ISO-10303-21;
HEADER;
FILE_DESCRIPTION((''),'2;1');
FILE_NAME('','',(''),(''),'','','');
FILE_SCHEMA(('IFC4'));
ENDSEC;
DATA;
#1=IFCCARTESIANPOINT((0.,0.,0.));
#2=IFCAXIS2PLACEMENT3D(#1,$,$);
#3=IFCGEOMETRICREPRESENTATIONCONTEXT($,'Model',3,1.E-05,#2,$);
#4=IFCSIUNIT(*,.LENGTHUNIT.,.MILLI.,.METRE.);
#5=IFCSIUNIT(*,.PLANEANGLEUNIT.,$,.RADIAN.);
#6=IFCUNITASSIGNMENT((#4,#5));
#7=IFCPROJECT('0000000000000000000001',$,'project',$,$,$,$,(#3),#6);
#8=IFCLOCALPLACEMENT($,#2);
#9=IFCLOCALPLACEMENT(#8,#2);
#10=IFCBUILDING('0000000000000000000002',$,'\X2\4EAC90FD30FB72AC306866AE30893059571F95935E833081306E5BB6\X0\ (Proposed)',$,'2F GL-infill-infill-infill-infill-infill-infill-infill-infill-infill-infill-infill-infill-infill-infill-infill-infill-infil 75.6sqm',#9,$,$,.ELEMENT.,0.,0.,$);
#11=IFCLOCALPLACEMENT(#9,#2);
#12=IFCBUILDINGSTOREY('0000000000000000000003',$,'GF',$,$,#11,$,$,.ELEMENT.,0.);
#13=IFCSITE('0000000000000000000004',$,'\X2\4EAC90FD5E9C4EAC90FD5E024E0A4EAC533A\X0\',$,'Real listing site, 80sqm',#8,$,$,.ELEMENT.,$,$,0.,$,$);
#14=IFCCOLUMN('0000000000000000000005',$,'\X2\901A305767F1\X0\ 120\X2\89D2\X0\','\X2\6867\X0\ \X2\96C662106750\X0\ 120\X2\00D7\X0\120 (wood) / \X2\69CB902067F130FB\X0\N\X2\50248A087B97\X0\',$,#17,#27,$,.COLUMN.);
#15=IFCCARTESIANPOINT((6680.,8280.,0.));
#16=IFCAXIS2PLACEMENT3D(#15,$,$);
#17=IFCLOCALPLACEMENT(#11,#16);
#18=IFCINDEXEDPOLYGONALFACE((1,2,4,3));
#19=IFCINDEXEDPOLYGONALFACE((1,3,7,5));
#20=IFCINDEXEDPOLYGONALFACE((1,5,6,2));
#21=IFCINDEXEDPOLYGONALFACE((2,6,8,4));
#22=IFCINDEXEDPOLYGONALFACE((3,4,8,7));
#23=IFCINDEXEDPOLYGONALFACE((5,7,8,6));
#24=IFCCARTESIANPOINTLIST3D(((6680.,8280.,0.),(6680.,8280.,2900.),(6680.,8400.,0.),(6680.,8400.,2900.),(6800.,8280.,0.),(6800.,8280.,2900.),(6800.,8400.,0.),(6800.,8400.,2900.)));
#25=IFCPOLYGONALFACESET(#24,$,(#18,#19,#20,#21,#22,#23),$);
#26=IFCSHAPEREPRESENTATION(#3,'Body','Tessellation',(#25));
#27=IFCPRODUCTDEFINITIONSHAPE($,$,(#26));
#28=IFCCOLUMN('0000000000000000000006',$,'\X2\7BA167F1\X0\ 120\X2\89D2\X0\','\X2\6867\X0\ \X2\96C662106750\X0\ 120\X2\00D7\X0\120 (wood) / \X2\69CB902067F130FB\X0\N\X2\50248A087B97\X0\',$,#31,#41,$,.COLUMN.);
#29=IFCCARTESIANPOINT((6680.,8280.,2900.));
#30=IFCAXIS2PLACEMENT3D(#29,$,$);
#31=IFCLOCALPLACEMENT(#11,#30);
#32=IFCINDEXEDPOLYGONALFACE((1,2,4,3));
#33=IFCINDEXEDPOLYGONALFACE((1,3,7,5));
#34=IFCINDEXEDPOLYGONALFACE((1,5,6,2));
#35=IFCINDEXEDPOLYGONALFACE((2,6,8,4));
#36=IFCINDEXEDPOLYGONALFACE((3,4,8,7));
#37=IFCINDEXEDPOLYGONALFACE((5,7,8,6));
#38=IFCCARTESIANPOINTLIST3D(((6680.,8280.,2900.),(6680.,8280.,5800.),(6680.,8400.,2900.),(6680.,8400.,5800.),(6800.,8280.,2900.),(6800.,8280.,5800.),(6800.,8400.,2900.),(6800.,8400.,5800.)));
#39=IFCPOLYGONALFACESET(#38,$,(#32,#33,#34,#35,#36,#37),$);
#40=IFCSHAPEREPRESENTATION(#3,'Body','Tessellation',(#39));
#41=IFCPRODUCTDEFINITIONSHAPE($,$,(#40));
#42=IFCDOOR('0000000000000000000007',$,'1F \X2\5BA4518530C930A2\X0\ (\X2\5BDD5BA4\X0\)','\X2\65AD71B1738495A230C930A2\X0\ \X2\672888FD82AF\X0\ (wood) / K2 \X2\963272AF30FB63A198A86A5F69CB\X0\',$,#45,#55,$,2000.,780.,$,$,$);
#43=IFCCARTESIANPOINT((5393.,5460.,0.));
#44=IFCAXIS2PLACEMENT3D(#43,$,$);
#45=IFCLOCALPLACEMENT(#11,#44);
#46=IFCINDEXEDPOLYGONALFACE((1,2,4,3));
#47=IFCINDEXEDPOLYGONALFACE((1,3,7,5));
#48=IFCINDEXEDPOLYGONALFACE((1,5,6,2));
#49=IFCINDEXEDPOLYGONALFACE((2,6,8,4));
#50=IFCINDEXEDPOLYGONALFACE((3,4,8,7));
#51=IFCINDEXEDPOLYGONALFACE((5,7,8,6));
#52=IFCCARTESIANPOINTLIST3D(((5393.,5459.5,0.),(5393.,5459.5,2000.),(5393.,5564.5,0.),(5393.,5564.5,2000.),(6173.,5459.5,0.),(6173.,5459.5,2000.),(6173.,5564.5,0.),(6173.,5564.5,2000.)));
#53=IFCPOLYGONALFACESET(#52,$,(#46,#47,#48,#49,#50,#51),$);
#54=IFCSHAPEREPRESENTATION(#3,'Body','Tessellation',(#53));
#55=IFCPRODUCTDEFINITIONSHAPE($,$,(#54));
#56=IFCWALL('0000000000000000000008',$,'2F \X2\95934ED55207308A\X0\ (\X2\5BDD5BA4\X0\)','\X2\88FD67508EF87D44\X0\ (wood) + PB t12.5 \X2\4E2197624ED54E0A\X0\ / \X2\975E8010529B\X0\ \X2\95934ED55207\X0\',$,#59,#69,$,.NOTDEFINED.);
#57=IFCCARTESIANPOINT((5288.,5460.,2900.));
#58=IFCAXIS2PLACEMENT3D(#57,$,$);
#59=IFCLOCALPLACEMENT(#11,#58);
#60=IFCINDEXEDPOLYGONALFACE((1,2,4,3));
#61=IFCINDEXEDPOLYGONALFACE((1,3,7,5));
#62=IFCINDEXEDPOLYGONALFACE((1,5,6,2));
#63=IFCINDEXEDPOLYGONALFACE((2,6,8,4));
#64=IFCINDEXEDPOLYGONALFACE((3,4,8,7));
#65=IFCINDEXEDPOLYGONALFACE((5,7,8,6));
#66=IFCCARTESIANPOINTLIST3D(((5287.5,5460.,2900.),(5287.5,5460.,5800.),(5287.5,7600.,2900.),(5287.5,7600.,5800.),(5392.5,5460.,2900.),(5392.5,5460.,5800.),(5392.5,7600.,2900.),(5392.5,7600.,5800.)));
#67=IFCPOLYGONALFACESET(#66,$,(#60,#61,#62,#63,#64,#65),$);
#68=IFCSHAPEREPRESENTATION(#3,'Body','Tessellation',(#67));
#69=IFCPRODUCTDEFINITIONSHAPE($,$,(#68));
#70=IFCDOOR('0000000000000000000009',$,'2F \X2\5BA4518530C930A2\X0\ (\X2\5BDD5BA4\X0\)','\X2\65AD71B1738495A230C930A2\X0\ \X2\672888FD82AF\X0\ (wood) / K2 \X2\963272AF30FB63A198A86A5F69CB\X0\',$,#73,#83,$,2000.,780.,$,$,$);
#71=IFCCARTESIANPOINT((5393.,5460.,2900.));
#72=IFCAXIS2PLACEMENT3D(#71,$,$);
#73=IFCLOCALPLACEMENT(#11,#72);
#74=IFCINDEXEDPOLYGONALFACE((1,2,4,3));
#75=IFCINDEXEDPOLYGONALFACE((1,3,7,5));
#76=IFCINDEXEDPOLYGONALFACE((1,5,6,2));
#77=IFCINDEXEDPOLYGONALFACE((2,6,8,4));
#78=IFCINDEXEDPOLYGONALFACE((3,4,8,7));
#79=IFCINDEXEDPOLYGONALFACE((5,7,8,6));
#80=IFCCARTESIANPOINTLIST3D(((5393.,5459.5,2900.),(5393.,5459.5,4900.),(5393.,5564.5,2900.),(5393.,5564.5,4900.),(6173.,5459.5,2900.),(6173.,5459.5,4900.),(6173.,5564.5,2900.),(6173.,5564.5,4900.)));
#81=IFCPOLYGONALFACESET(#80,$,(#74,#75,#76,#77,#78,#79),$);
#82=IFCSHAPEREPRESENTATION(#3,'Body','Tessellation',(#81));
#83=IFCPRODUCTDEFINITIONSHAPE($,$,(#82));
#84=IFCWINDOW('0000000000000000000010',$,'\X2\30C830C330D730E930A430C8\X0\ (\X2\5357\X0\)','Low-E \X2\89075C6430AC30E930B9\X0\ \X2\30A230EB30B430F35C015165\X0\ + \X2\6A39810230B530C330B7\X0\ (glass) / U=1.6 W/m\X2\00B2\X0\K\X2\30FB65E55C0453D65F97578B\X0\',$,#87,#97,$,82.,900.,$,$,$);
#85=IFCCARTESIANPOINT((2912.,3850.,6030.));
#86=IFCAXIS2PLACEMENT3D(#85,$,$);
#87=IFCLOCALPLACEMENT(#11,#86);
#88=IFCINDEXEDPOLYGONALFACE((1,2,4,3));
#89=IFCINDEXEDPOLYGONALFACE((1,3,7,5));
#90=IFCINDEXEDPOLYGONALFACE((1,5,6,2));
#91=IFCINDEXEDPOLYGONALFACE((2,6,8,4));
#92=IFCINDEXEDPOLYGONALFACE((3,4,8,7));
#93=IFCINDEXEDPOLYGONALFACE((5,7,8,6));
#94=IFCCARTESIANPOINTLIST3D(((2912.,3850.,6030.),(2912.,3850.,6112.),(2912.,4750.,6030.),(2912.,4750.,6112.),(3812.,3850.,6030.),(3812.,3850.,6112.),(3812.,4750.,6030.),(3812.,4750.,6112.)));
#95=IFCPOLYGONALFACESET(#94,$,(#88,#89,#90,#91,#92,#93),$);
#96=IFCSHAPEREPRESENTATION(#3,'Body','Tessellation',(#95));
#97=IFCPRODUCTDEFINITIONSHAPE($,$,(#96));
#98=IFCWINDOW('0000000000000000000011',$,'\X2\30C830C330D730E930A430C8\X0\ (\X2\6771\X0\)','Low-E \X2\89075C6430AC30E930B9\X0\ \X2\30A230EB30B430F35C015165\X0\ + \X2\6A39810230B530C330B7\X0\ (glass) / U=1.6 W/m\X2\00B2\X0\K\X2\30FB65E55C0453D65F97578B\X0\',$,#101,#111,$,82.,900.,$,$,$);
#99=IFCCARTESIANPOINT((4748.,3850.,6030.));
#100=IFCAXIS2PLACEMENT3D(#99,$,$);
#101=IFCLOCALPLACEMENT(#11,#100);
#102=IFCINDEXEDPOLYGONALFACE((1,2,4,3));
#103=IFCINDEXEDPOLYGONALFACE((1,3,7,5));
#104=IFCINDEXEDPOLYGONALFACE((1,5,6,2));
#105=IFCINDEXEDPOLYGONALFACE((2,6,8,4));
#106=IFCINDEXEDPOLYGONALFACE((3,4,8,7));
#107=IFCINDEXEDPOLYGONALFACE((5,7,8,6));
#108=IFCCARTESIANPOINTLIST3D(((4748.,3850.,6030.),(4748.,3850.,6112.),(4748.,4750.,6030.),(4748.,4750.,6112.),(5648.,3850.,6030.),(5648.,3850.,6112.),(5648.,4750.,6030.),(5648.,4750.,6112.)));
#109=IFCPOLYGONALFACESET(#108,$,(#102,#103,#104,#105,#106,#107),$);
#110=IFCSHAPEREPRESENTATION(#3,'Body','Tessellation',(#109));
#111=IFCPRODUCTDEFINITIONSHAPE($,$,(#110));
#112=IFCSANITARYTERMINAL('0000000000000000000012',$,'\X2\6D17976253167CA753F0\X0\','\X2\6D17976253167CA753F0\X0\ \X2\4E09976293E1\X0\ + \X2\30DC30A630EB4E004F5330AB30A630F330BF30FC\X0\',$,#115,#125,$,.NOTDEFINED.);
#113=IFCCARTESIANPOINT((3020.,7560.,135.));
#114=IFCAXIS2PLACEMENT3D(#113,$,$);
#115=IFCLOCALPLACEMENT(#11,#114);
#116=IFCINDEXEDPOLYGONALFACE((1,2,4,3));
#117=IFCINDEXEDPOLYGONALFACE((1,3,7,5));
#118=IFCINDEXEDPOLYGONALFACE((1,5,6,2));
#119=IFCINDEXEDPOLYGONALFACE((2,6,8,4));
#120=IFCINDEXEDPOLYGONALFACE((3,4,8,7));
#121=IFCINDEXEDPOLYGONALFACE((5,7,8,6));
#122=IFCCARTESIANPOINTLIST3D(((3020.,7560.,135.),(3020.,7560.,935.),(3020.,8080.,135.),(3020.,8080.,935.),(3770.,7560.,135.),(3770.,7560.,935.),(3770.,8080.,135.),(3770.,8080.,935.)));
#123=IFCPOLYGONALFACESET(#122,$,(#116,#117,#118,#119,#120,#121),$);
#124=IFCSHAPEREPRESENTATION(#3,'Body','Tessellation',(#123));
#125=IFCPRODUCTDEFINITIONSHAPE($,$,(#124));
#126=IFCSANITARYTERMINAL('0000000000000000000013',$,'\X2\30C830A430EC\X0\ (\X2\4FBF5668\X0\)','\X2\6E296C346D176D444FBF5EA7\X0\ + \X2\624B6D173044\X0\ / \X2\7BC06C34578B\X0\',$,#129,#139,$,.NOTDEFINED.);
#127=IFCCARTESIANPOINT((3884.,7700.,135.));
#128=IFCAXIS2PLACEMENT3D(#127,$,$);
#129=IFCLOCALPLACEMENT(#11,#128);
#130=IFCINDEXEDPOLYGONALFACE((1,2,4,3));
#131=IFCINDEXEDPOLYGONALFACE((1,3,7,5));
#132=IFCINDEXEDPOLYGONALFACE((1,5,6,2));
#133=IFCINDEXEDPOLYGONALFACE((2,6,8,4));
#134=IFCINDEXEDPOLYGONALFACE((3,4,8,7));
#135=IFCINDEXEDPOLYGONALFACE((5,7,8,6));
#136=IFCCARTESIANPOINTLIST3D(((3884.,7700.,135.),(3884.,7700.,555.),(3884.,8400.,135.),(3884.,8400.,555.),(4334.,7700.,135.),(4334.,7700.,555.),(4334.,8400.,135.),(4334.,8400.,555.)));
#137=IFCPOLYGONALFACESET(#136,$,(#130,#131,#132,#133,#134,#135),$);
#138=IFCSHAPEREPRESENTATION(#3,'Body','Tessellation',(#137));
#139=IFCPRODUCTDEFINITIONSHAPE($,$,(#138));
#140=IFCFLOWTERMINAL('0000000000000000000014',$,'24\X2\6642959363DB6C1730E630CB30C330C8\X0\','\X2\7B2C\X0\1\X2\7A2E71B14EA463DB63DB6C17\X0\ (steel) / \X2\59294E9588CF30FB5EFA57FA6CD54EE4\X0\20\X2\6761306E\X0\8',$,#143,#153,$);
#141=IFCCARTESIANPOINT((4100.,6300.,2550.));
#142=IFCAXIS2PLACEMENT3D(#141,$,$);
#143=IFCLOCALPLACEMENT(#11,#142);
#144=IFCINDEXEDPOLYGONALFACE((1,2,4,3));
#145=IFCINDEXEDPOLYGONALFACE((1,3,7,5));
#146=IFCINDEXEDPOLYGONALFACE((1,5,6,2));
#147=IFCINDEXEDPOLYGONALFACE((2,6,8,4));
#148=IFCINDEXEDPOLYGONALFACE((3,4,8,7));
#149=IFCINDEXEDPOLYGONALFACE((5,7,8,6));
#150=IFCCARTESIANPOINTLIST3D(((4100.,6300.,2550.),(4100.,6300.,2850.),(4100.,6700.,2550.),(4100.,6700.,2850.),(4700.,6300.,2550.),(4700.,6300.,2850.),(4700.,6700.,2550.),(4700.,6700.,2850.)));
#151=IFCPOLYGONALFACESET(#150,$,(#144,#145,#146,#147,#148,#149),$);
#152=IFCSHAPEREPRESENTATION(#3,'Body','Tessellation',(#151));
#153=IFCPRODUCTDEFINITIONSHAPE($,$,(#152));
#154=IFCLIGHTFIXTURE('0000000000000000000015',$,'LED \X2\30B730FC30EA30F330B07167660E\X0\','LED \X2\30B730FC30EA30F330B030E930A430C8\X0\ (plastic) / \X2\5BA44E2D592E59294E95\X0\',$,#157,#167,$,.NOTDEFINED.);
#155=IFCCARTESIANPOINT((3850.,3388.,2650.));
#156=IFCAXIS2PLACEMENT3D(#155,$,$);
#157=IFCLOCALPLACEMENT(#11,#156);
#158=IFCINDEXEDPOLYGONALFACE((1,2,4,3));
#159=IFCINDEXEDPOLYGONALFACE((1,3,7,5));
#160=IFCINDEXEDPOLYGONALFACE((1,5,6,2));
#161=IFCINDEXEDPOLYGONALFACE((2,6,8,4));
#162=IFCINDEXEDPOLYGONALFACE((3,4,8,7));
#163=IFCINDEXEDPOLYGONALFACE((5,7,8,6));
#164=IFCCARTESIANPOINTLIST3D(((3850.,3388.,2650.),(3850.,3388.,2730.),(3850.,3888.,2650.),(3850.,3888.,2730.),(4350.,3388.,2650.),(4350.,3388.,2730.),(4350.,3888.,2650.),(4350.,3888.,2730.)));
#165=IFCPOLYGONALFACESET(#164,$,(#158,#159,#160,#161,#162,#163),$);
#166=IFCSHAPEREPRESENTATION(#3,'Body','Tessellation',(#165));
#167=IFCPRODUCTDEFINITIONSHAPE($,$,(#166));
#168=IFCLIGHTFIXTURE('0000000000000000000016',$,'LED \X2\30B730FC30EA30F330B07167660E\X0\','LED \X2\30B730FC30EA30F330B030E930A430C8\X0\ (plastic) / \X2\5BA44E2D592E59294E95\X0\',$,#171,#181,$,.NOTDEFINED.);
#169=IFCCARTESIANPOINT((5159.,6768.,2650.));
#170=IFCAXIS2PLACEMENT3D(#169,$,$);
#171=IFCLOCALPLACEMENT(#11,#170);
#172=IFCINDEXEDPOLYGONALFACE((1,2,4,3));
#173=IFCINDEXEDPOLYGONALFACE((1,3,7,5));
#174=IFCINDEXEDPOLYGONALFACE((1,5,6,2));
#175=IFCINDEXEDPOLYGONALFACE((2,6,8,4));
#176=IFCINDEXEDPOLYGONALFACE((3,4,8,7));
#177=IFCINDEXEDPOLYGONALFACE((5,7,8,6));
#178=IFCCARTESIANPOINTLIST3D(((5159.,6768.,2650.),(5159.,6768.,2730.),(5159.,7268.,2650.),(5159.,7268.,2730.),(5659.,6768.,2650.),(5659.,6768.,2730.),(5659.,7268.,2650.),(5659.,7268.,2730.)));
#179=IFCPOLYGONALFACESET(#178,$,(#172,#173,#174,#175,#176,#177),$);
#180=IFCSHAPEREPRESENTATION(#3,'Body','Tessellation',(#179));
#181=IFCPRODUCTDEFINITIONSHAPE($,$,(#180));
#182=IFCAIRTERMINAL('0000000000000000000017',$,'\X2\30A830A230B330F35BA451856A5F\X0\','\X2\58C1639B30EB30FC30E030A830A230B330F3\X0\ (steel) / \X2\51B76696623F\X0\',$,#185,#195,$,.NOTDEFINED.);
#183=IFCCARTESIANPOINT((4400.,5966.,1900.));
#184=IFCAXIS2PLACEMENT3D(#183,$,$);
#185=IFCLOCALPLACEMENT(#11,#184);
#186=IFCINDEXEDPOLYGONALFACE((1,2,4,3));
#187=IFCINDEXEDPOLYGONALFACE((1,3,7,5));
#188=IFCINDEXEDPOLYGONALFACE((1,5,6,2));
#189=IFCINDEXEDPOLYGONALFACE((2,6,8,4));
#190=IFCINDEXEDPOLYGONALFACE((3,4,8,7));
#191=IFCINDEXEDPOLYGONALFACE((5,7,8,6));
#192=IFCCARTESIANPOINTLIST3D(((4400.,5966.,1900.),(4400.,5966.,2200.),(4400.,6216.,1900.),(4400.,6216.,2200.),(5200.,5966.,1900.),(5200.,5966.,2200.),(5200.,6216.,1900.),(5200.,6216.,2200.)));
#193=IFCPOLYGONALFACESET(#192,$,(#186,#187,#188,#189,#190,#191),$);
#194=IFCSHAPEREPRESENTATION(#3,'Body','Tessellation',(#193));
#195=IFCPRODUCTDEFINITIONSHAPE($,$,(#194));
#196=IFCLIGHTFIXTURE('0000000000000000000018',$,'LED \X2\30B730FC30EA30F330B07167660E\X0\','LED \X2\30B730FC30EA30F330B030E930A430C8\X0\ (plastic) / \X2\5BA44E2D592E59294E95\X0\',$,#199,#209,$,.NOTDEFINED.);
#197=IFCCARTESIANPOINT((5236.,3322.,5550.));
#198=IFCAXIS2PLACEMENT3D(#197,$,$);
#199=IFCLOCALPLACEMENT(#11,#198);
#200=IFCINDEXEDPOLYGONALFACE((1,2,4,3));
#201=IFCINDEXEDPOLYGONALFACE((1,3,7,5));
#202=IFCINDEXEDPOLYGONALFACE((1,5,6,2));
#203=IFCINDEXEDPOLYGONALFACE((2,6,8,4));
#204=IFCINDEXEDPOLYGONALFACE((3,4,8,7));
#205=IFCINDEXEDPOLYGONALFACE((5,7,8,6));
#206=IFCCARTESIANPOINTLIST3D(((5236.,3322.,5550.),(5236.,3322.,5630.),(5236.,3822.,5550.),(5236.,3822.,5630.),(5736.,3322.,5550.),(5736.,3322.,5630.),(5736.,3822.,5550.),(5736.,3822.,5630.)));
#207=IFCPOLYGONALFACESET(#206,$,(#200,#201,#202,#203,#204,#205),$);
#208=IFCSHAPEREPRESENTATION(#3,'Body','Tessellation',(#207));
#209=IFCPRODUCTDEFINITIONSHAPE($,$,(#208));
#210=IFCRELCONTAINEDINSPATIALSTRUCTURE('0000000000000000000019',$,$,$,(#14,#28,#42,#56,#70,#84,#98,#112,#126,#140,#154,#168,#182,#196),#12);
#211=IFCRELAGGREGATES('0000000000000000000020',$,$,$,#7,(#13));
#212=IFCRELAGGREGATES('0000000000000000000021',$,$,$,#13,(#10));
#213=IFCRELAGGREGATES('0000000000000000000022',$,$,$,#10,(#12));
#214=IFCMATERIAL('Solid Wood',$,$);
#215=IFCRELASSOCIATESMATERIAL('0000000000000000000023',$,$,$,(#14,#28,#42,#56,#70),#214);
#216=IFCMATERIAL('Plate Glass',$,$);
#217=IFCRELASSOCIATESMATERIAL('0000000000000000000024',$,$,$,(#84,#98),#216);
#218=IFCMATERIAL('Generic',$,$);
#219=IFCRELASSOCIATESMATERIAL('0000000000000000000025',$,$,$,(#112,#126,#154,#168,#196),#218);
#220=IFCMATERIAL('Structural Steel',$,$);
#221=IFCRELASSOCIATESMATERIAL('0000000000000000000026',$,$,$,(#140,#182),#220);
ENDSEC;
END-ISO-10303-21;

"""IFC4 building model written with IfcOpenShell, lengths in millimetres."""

from ifc_helpers import new_model, si_unit, frame, frame_2d, origin, place, context, project, spatial, rectangle, extrude, material, element, save


model = new_model("IFC4")

# Units and contexts
model_context = context("Model", 3, precision=1e-05, world=origin())
ifc_project = project(units=[si_unit("LENGTHUNIT", "METRE", prefix="MILLI"), si_unit("PLANEANGLEUNIT", "RADIAN")], contexts=[model_context])

# Site, building, storey
site_placement = place(None, origin())
site = spatial("IfcSite", under=ifc_project, at=site_placement, Name="京都府京都市上京区", ObjectType="Real listing site, 80sqm", CompositionType="ELEMENT", RefElevation=0.0)
building_placement = place(site_placement, origin())
building = spatial("IfcBuilding", under=site, at=building_placement, Name="京都・犬と暮らす土間広めの家 (Proposed)", ObjectType="2F GL-infill-infill-infill-infill-infill-infill-infill-infill-infill-infill-infill-infill-infill-infill-infill-infill-infil 75.6sqm", CompositionType="ELEMENT", ElevationOfRefHeight=0.0, ElevationOfTerrain=0.0)
storey_placement = place(building_placement, origin())
storey = spatial("IfcBuildingStorey", under=building, at=storey_placement, Name="GF", CompositionType="ELEMENT", Elevation=0.0)

# Columns
ifc_material_1 = material(Name="Solid Wood")
column_1_placement = place(storey_placement, frame((6680.0, 8280.0, 0.0)))
element("IfcColumn", 1, at=column_1_placement, inside=storey, material=ifc_material_1, Name="通し柱 120角", Description="桧 集成材 120×120 (wood) / 構造柱・N値計算", PredefinedType="COLUMN", context=model_context, shape_type="SweptSolid", body=[
    extrude(rectangle(XDim=120.0, YDim=120.0, at=frame_2d((60.0, 60.0))), frame((6680.0, 8280.0, 0.0)), (0.0, 0.0, 1.0), 2900.0),
])
column_2_placement = place(storey_placement, frame((6680.0, 8280.0, 2900.0)))
element("IfcColumn", 2, at=column_2_placement, inside=storey, material=ifc_material_1, Name="管柱 120角", Description="桧 集成材 120×120 (wood) / 構造柱・N値計算", PredefinedType="COLUMN", context=model_context, shape_type="SweptSolid", body=[
    extrude(rectangle(XDim=120.0, YDim=120.0, at=frame_2d((60.0, 60.0))), frame((6680.0, 8280.0, 2900.0)), (0.0, 0.0, 1.0), 2900.0),
])

# Door
door_1_placement = place(storey_placement, frame((5393.0, 5460.0, 0.0)))
element("IfcDoor", 3, at=door_1_placement, inside=storey, material=ifc_material_1, Name="1F 室内ドア (寝室)", Description="断熱玄関ドア 木製芯 (wood) / K2 防犯・採風機構", OverallHeight=2000.0, OverallWidth=780.0, context=model_context, shape_type="SweptSolid", body=[
    extrude(rectangle(XDim=780.0, YDim=105.0, at=frame_2d((390.0, 52.0))), frame((5393.0, 5460.0, 0.0)), (0.0, 0.0, 1.0), 2000.0),
])

# Wall
wall_1_placement = place(storey_placement, frame((5288.0, 5460.0, 2900.0)))
element("IfcWall", 4, at=wall_1_placement, inside=storey, material=ifc_material_1, Name="2F 間仕切り (寝室)", Description="製材軸組 (wood) + PB t12.5 両面仕上 / 非耐力 間仕切", PredefinedType="NOTDEFINED", context=model_context, shape_type="SweptSolid", body=[
    extrude(rectangle(XDim=105.0, YDim=2140.0, at=frame_2d((52.0, 1070.0))), frame((5288.0, 5460.0, 2900.0)), (0.0, 0.0, 1.0), 2900.0),
])

# Door
door_2_placement = place(storey_placement, frame((5393.0, 5460.0, 2900.0)))
element("IfcDoor", 5, at=door_2_placement, inside=storey, material=ifc_material_1, Name="2F 室内ドア (寝室)", Description="断熱玄関ドア 木製芯 (wood) / K2 防犯・採風機構", OverallHeight=2000.0, OverallWidth=780.0, context=model_context, shape_type="SweptSolid", body=[
    extrude(rectangle(XDim=780.0, YDim=105.0, at=frame_2d((390.0, 52.0))), frame((5393.0, 5460.0, 2900.0)), (0.0, 0.0, 1.0), 2000.0),
])

# Windows
ifc_material_2 = material(Name="Plate Glass")
window_1_placement = place(storey_placement, frame((2912.0, 3850.0, 6030.0)))
element("IfcWindow", 6, at=window_1_placement, inside=storey, material=ifc_material_2, Name="トップライト (南)", Description="Low-E 複層ガラス アルゴン封入 + 樹脂サッシ (glass) / U=1.6 W/m²K・日射取得型", OverallHeight=82.0, OverallWidth=900.0, context=model_context, shape_type="SweptSolid", body=[
    extrude(rectangle(XDim=900.0, YDim=900.0, at=frame_2d((450.0, 450.0))), frame((2912.0, 3850.0, 6030.0)), (0.0, 0.0, 1.0), 82.0),
])
window_2_placement = place(storey_placement, frame((4748.0, 3850.0, 6030.0)))
element("IfcWindow", 7, at=window_2_placement, inside=storey, material=ifc_material_2, Name="トップライト (東)", Description="Low-E 複層ガラス アルゴン封入 + 樹脂サッシ (glass) / U=1.6 W/m²K・日射取得型", OverallHeight=82.0, OverallWidth=900.0, context=model_context, shape_type="SweptSolid", body=[
    extrude(rectangle(XDim=900.0, YDim=900.0, at=frame_2d((450.0, 450.0))), frame((4748.0, 3850.0, 6030.0)), (0.0, 0.0, 1.0), 82.0),
])

# Sanitary terminals
ifc_material_3 = material(Name="Generic")
sanitary_terminal_1_placement = place(storey_placement, frame((3020.0, 7560.0, 135.0)))
element("IfcSanitaryTerminal", 8, at=sanitary_terminal_1_placement, inside=storey, material=ifc_material_3, Name="洗面化粧台", Description="洗面化粧台 三面鏡 + ボウル一体カウンター", PredefinedType="NOTDEFINED", context=model_context, shape_type="SweptSolid", body=[
    extrude(rectangle(XDim=750.0, YDim=520.0, at=frame_2d((375.0, 260.0))), frame((3020.0, 7560.0, 135.0)), (0.0, 0.0, 1.0), 800.0),
])
sanitary_terminal_2_placement = place(storey_placement, frame((3884.0, 7700.0, 135.0)))
element("IfcSanitaryTerminal", 9, at=sanitary_terminal_2_placement, inside=storey, material=ifc_material_3, Name="トイレ (便器)", Description="温水洗浄便座 + 手洗い / 節水型", PredefinedType="NOTDEFINED", context=model_context, shape_type="SweptSolid", body=[
    extrude(rectangle(XDim=450.0, YDim=700.0, at=frame_2d((225.0, 350.0))), frame((3884.0, 7700.0, 135.0)), (0.0, 0.0, 1.0), 420.0),
])

# Flow terminal
ifc_material_4 = material(Name="Structural Steel")
flow_terminal_placement = place(storey_placement, frame((4100.0, 6300.0, 2550.0)))
element("IfcFlowTerminal", 10, at=flow_terminal_placement, inside=storey, material=ifc_material_4, Name="24時間換気ユニット", Description="第1種熱交換換気 (steel) / 天井裏・建基法令20条の8", context=model_context, shape_type="SweptSolid", body=[
    extrude(rectangle(XDim=600.0, YDim=400.0, at=frame_2d((300.0, 200.0))), frame((4100.0, 6300.0, 2550.0)), (0.0, 0.0, 1.0), 300.0),
])

# Light fixtures
light_fixture_1_placement = place(storey_placement, frame((3850.0, 3388.0, 2650.0)))
element("IfcLightFixture", 11, at=light_fixture_1_placement, inside=storey, material=ifc_material_3, Name="LED シーリング照明", Description="LED シーリングライト (plastic) / 室中央天井", PredefinedType="NOTDEFINED", context=model_context, shape_type="SweptSolid", body=[
    extrude(rectangle(XDim=500.0, YDim=500.0, at=frame_2d((250.0, 250.0))), frame((3850.0, 3388.0, 2650.0)), (0.0, 0.0, 1.0), 80.0),
])
light_fixture_2_placement = place(storey_placement, frame((5159.0, 6768.0, 2650.0)))
element("IfcLightFixture", 12, at=light_fixture_2_placement, inside=storey, material=ifc_material_3, Name="LED シーリング照明", Description="LED シーリングライト (plastic) / 室中央天井", PredefinedType="NOTDEFINED", context=model_context, shape_type="SweptSolid", body=[
    extrude(rectangle(XDim=500.0, YDim=500.0, at=frame_2d((250.0, 250.0))), frame((5159.0, 6768.0, 2650.0)), (0.0, 0.0, 1.0), 80.0),
])

# Air terminal
air_terminal_placement = place(storey_placement, frame((4400.0, 5966.0, 1900.0)))
element("IfcAirTerminal", 13, at=air_terminal_placement, inside=storey, material=ifc_material_4, Name="エアコン室内機", Description="壁掛ルームエアコン (steel) / 冷暖房", PredefinedType="NOTDEFINED", context=model_context, shape_type="SweptSolid", body=[
    extrude(rectangle(XDim=800.0, YDim=250.0, at=frame_2d((400.0, 125.0))), frame((4400.0, 5966.0, 1900.0)), (0.0, 0.0, 1.0), 300.0),
])

# Light fixture
light_fixture_3_placement = place(storey_placement, frame((5236.0, 3322.0, 5550.0)))
element("IfcLightFixture", 14, at=light_fixture_3_placement, inside=storey, material=ifc_material_3, Name="LED シーリング照明", Description="LED シーリングライト (plastic) / 室中央天井", PredefinedType="NOTDEFINED", context=model_context, shape_type="SweptSolid", body=[
    extrude(rectangle(XDim=500.0, YDim=500.0, at=frame_2d((250.0, 250.0))), frame((5236.0, 3322.0, 5550.0)), (0.0, 0.0, 1.0), 80.0),
])

save(model, "model.ifc")
